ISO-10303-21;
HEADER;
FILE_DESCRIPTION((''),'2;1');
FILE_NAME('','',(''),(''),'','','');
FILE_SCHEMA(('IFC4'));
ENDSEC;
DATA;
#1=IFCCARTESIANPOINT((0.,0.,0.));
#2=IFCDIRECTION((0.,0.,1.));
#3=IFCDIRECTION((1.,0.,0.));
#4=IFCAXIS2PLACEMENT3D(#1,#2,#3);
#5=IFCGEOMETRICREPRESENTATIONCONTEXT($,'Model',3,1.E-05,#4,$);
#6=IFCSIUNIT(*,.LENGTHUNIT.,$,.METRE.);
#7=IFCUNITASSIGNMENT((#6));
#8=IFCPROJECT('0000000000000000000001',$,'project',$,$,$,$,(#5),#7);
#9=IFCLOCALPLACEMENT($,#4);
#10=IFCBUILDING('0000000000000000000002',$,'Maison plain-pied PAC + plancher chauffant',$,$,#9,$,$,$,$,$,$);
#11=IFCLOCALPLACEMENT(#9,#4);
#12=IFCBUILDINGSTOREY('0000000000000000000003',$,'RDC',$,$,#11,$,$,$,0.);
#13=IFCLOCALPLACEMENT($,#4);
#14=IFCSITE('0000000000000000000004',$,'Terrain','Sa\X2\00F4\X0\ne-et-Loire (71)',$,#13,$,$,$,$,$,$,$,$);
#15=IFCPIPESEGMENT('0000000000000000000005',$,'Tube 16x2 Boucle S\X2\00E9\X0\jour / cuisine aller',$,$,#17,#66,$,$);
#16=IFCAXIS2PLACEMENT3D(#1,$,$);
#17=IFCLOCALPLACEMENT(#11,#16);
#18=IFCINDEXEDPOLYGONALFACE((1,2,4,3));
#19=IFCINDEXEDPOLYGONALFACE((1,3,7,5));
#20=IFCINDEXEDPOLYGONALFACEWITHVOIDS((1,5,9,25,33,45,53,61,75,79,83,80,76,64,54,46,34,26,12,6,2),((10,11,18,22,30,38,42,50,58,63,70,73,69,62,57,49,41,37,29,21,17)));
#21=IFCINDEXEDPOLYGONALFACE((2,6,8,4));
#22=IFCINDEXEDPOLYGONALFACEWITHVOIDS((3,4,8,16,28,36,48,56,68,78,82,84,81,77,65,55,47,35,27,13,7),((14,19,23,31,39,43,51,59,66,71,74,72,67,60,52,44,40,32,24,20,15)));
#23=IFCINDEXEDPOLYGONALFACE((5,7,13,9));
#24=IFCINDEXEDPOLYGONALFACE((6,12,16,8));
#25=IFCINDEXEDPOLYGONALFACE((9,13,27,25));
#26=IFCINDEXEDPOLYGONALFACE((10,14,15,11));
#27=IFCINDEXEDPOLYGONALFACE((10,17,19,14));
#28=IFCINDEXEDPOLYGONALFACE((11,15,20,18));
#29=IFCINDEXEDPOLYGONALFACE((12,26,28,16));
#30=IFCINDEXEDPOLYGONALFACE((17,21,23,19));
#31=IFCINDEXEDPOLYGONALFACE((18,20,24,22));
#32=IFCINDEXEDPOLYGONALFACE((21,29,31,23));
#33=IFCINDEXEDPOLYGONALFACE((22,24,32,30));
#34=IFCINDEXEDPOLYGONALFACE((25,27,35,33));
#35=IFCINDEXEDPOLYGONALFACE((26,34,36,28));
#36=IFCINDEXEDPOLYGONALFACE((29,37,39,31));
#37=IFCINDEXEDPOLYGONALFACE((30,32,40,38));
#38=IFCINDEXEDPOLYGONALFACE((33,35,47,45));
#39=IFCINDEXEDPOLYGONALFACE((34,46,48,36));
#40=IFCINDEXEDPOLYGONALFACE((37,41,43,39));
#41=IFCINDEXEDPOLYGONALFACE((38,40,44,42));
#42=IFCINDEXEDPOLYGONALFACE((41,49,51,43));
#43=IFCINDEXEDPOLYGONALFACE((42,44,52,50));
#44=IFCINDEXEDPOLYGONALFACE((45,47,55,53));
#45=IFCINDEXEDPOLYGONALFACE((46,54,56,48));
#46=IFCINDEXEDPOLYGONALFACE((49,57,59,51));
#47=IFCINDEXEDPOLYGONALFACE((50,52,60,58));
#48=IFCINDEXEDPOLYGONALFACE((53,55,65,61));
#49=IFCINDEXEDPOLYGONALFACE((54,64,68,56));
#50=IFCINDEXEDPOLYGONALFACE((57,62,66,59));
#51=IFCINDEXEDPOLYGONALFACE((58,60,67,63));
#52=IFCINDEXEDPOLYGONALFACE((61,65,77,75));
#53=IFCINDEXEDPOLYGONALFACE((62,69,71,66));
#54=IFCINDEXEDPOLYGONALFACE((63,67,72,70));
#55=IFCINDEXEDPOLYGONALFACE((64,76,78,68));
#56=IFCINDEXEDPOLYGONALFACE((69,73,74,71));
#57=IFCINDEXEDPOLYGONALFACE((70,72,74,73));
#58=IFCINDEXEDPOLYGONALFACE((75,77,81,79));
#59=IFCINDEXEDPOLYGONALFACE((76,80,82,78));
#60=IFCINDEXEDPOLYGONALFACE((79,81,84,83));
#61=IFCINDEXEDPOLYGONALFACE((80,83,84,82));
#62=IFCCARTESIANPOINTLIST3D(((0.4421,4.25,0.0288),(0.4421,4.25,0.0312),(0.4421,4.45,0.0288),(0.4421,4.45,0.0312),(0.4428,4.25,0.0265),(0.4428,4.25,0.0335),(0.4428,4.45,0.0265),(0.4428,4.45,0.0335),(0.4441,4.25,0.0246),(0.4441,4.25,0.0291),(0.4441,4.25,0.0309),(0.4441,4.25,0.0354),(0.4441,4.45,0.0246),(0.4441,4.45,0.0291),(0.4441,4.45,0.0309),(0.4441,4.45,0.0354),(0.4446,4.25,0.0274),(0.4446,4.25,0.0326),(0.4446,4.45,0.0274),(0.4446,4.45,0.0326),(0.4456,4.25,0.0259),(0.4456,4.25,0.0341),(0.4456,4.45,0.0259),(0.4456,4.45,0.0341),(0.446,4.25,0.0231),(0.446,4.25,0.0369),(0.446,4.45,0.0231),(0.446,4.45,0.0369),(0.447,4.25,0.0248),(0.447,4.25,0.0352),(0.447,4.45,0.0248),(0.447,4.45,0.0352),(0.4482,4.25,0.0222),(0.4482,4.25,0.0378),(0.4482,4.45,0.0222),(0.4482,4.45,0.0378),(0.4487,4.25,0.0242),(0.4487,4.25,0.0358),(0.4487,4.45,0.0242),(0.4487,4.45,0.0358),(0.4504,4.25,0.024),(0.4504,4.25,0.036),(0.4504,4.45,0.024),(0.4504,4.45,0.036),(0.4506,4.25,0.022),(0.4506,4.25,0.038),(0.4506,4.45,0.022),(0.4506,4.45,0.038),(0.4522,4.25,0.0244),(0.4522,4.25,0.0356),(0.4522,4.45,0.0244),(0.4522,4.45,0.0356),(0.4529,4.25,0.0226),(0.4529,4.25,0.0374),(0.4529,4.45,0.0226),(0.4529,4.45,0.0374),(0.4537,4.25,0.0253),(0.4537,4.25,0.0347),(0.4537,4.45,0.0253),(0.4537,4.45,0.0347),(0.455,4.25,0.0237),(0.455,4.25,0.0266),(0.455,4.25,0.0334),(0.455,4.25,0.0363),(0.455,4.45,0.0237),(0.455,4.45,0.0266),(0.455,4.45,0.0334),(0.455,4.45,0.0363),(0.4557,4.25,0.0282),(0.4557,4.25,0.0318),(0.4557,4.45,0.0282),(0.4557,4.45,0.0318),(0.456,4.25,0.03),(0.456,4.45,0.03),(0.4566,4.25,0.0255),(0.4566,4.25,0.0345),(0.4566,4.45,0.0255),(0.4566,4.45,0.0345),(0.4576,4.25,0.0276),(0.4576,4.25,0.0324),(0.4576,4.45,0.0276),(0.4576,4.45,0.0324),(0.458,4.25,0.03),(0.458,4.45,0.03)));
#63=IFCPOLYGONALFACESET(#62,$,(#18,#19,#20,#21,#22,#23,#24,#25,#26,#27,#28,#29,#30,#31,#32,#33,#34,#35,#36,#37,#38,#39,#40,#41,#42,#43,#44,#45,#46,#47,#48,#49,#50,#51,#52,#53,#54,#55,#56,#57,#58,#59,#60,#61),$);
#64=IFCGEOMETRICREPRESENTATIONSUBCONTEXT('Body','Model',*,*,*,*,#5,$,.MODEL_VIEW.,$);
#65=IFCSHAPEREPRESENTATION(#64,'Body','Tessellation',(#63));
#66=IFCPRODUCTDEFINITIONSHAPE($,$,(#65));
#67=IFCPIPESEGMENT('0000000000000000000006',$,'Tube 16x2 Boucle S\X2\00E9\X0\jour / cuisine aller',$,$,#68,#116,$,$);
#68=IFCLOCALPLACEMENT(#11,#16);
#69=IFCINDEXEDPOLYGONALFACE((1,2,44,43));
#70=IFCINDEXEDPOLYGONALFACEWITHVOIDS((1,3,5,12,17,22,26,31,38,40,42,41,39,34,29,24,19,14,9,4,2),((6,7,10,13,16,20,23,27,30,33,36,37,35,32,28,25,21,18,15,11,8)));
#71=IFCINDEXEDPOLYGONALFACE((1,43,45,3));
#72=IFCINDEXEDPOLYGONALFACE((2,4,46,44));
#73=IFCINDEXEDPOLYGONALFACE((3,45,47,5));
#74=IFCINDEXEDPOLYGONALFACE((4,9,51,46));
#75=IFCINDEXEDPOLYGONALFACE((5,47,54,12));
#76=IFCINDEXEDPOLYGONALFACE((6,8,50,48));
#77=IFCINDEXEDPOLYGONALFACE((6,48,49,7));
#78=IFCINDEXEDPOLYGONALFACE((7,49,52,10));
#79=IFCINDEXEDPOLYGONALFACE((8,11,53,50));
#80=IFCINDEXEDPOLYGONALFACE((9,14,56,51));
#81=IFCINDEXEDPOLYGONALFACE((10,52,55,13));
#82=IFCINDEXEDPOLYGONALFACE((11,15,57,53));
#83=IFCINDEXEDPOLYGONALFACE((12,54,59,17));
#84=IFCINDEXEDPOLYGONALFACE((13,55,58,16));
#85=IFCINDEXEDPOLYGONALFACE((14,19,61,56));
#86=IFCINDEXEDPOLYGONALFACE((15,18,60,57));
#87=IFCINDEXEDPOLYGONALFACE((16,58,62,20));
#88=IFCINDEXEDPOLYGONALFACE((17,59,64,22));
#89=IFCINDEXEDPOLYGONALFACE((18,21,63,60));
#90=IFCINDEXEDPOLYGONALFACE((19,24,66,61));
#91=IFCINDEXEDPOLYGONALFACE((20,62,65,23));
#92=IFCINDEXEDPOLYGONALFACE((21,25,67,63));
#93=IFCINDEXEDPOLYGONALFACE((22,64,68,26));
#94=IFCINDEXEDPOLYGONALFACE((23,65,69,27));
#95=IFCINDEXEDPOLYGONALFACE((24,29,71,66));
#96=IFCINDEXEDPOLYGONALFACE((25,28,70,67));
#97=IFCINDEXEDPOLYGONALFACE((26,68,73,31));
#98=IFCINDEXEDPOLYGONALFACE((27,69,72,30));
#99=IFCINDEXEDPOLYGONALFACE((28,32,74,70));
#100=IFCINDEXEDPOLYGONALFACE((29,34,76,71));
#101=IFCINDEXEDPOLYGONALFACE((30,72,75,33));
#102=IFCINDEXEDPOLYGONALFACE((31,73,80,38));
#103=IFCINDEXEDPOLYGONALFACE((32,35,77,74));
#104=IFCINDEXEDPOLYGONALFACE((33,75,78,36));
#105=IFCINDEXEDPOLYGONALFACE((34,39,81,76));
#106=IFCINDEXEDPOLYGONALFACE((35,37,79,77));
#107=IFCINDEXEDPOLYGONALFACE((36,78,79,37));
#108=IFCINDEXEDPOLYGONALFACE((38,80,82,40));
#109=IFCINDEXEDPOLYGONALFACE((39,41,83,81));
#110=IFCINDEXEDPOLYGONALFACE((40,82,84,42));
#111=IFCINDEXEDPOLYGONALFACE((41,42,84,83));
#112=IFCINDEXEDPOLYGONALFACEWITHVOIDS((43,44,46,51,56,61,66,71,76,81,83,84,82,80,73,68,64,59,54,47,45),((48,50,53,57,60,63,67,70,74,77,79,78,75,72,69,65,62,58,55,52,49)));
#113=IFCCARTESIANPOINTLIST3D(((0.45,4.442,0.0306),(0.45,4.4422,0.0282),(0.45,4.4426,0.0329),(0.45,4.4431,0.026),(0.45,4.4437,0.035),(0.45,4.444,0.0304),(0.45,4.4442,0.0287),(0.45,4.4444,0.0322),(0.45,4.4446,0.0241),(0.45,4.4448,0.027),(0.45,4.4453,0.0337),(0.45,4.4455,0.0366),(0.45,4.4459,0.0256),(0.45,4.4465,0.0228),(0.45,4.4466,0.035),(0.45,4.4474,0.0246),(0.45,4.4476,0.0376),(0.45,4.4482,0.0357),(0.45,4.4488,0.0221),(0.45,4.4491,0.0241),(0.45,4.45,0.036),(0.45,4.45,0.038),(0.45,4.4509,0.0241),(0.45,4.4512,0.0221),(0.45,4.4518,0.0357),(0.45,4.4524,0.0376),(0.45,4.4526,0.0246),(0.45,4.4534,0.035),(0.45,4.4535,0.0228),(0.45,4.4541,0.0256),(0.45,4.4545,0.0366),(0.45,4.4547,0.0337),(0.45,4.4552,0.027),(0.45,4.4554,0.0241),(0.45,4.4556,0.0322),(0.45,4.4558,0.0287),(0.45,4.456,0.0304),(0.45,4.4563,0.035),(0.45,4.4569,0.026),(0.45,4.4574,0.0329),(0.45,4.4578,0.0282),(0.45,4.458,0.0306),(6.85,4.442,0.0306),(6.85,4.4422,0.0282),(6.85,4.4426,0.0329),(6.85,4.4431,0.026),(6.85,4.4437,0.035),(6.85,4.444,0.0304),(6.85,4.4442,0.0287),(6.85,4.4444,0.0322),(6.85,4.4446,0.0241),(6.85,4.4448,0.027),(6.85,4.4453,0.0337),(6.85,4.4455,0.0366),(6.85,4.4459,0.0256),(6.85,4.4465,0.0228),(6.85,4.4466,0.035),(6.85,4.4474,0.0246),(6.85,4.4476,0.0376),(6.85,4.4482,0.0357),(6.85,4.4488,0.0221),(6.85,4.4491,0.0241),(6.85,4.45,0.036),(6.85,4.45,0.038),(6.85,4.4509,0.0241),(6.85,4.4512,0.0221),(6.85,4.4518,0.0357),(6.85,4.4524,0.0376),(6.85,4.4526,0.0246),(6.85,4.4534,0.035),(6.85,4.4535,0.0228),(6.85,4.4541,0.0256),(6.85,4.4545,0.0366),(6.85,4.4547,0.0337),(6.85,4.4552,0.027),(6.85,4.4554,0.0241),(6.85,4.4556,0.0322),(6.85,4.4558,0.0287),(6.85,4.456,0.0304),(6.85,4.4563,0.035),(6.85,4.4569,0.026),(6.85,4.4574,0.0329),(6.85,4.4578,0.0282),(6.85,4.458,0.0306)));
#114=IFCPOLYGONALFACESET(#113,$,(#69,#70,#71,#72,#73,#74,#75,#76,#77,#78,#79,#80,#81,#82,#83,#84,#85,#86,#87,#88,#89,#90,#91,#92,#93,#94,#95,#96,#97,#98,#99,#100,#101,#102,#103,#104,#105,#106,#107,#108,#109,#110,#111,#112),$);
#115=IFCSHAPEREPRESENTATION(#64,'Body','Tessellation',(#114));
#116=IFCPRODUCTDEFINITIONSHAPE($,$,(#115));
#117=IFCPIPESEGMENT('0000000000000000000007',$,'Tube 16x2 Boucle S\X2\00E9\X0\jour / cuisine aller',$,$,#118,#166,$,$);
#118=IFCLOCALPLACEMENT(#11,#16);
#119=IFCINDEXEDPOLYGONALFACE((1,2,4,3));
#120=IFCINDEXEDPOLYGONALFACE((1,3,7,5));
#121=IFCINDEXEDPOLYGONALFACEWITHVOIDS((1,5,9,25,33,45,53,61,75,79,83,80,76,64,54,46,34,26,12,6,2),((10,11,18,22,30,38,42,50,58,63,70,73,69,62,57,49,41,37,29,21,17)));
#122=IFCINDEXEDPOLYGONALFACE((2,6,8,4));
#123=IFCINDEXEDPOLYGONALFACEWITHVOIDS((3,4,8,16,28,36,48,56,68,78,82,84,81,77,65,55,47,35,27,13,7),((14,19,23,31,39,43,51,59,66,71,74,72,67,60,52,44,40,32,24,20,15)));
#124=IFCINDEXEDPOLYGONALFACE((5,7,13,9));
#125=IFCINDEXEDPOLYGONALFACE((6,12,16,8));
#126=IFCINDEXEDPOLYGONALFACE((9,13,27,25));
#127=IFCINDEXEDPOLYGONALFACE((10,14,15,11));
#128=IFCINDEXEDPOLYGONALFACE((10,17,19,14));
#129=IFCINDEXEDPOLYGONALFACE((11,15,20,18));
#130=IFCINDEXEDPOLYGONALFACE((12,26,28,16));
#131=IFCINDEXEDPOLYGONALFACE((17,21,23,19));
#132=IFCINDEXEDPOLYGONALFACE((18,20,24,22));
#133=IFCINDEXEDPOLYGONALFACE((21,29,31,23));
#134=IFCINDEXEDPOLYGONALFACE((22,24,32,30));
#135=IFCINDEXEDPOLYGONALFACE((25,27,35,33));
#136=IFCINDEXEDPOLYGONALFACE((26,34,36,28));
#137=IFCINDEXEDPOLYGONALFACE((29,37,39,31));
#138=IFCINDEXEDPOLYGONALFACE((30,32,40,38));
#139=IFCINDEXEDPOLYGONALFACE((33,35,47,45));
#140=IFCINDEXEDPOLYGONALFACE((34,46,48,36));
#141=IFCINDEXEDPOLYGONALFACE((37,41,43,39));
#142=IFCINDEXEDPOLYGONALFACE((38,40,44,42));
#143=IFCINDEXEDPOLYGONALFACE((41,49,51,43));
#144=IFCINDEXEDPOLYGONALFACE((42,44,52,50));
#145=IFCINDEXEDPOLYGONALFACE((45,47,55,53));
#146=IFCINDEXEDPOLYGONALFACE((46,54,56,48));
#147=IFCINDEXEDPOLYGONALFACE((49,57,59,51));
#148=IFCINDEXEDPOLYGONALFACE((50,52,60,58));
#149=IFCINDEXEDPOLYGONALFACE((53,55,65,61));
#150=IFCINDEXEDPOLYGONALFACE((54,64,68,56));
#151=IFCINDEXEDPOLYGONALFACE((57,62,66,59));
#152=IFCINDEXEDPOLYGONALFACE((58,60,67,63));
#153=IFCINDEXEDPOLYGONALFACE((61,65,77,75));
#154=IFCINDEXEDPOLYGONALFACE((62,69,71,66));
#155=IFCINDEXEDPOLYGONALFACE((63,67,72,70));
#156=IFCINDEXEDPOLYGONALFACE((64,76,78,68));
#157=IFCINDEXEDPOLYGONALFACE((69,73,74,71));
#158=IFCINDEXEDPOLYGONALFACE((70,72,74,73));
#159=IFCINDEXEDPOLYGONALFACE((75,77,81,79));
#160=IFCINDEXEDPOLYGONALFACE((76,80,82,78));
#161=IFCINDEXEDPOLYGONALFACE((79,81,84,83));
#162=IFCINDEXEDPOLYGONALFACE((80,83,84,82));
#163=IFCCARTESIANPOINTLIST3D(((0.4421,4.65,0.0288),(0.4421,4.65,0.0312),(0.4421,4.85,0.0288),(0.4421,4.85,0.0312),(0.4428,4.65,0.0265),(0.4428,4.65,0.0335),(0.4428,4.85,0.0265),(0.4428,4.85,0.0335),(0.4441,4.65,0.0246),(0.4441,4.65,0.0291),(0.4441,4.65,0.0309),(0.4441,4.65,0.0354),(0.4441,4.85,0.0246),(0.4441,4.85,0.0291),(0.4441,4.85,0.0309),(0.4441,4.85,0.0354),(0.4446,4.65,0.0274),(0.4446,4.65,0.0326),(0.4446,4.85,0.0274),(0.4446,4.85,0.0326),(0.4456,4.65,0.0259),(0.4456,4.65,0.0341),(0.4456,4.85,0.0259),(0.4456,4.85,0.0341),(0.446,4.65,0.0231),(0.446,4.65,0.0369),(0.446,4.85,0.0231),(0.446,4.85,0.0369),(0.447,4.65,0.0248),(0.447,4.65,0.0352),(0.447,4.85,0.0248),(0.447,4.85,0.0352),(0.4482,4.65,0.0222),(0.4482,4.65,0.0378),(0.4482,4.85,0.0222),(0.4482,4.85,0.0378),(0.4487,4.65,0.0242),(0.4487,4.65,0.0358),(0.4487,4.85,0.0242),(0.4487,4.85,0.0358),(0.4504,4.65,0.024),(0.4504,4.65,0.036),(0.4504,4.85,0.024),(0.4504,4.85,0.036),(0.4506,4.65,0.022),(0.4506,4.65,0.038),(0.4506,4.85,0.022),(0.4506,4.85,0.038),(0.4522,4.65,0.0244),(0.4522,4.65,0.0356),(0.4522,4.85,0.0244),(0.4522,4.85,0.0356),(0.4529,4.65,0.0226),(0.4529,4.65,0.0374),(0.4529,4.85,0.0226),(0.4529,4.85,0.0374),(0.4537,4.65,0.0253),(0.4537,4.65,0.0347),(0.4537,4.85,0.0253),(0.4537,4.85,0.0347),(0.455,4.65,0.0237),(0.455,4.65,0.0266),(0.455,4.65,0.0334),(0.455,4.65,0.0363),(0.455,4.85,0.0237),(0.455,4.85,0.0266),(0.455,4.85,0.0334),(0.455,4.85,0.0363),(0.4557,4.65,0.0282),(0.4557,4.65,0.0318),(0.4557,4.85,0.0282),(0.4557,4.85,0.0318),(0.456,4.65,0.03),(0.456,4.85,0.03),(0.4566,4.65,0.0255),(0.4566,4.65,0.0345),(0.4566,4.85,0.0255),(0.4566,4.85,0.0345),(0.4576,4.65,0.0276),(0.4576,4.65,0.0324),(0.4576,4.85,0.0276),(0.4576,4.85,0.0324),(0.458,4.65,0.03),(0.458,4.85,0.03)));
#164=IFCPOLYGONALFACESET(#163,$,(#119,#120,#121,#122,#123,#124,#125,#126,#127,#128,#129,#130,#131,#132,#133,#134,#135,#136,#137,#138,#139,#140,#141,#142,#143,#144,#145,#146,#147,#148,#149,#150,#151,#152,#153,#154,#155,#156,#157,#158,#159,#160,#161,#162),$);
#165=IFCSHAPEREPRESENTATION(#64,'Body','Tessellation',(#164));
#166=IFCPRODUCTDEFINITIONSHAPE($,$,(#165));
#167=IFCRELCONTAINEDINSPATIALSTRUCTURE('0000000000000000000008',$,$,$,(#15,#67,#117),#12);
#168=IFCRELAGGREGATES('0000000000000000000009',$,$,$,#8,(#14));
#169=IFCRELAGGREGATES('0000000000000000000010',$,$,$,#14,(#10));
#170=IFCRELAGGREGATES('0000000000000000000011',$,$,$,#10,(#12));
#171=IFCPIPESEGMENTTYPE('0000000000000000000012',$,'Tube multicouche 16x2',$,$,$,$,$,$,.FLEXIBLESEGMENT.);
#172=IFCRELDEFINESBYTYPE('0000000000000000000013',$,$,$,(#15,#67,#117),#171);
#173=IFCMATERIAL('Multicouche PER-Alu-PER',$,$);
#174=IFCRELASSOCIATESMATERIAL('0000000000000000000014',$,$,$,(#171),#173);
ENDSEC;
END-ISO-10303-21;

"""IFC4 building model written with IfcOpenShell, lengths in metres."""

from ifc_helpers import new_model, si_unit, frame, origin_with_axes, place, context, subcontext, project, spatial, hollow_circle, extrude, material, type_object, element, save


model = new_model("IFC4")

# Units and contexts
model_context = context("Model", 3, precision=1e-05, world=origin_with_axes())
body_context = subcontext(model_context, "Body", "Model", "MODEL_VIEW")
ifc_project = project(units=[si_unit("LENGTHUNIT", "METRE")], contexts=[model_context])

# Site, building, storey
site_placement = place(None, origin_with_axes())
site = spatial("IfcSite", under=ifc_project, at=site_placement, Name="Terrain", Description="Saône-et-Loire (71)")
building_placement = place(None, origin_with_axes())
building = spatial("IfcBuilding", under=site, at=building_placement, Name="Maison plain-pied PAC + plancher chauffant")
storey_placement = place(building_placement, origin_with_axes())
storey = spatial("IfcBuildingStorey", under=building, at=storey_placement, Name="RDC", Elevation=0.0)

# Pipe segments
ifc_material = material(Name="Multicouche PER-Alu-PER")
pipe_segment_type = type_object("IfcPipeSegmentType", Name="Tube multicouche 16x2", PredefinedType="FLEXIBLESEGMENT", material=ifc_material)
pipe_segment_1_placement = place(storey_placement, frame((0.45, 4.25, 0.03), z_axis=(0.0, 1.0, 0.0), x_axis=(1.0, 0.0, 0.0)))
element("IfcPipeSegment", 1, at=pipe_segment_1_placement, inside=storey, type_object=pipe_segment_type, Name="Tube 16x2 Boucle Séjour / cuisine aller", context=body_context, shape_type="SweptSolid", body=[
    extrude(hollow_circle(Radius=0.008, WallThickness=0.002), origin_with_axes(), (0.0, 0.0, 1.0), 0.2),
])
pipe_segment_2_placement = place(storey_placement, frame((0.45, 4.45, 0.03), z_axis=(1.0, 0.0, 0.0), x_axis=(0.0, 0.0, 1.0)))
element("IfcPipeSegment", 2, at=pipe_segment_2_placement, inside=storey, type_object=pipe_segment_type, Name="Tube 16x2 Boucle Séjour / cuisine aller", context=body_context, shape_type="SweptSolid", body=[
    extrude(hollow_circle(Radius=0.008, WallThickness=0.002), origin_with_axes(), (0.0, 0.0, 1.0), 6.4),
])
pipe_segment_3_placement = place(storey_placement, frame((0.45, 4.65, 0.03), z_axis=(0.0, 1.0, 0.0), x_axis=(1.0, 0.0, 0.0)))
element("IfcPipeSegment", 3, at=pipe_segment_3_placement, inside=storey, type_object=pipe_segment_type, Name="Tube 16x2 Boucle Séjour / cuisine aller", context=body_context, shape_type="SweptSolid", body=[
    extrude(hollow_circle(Radius=0.008, WallThickness=0.002), origin_with_axes(), (0.0, 0.0, 1.0), 0.2),
])

save(model, "model.ifc")
